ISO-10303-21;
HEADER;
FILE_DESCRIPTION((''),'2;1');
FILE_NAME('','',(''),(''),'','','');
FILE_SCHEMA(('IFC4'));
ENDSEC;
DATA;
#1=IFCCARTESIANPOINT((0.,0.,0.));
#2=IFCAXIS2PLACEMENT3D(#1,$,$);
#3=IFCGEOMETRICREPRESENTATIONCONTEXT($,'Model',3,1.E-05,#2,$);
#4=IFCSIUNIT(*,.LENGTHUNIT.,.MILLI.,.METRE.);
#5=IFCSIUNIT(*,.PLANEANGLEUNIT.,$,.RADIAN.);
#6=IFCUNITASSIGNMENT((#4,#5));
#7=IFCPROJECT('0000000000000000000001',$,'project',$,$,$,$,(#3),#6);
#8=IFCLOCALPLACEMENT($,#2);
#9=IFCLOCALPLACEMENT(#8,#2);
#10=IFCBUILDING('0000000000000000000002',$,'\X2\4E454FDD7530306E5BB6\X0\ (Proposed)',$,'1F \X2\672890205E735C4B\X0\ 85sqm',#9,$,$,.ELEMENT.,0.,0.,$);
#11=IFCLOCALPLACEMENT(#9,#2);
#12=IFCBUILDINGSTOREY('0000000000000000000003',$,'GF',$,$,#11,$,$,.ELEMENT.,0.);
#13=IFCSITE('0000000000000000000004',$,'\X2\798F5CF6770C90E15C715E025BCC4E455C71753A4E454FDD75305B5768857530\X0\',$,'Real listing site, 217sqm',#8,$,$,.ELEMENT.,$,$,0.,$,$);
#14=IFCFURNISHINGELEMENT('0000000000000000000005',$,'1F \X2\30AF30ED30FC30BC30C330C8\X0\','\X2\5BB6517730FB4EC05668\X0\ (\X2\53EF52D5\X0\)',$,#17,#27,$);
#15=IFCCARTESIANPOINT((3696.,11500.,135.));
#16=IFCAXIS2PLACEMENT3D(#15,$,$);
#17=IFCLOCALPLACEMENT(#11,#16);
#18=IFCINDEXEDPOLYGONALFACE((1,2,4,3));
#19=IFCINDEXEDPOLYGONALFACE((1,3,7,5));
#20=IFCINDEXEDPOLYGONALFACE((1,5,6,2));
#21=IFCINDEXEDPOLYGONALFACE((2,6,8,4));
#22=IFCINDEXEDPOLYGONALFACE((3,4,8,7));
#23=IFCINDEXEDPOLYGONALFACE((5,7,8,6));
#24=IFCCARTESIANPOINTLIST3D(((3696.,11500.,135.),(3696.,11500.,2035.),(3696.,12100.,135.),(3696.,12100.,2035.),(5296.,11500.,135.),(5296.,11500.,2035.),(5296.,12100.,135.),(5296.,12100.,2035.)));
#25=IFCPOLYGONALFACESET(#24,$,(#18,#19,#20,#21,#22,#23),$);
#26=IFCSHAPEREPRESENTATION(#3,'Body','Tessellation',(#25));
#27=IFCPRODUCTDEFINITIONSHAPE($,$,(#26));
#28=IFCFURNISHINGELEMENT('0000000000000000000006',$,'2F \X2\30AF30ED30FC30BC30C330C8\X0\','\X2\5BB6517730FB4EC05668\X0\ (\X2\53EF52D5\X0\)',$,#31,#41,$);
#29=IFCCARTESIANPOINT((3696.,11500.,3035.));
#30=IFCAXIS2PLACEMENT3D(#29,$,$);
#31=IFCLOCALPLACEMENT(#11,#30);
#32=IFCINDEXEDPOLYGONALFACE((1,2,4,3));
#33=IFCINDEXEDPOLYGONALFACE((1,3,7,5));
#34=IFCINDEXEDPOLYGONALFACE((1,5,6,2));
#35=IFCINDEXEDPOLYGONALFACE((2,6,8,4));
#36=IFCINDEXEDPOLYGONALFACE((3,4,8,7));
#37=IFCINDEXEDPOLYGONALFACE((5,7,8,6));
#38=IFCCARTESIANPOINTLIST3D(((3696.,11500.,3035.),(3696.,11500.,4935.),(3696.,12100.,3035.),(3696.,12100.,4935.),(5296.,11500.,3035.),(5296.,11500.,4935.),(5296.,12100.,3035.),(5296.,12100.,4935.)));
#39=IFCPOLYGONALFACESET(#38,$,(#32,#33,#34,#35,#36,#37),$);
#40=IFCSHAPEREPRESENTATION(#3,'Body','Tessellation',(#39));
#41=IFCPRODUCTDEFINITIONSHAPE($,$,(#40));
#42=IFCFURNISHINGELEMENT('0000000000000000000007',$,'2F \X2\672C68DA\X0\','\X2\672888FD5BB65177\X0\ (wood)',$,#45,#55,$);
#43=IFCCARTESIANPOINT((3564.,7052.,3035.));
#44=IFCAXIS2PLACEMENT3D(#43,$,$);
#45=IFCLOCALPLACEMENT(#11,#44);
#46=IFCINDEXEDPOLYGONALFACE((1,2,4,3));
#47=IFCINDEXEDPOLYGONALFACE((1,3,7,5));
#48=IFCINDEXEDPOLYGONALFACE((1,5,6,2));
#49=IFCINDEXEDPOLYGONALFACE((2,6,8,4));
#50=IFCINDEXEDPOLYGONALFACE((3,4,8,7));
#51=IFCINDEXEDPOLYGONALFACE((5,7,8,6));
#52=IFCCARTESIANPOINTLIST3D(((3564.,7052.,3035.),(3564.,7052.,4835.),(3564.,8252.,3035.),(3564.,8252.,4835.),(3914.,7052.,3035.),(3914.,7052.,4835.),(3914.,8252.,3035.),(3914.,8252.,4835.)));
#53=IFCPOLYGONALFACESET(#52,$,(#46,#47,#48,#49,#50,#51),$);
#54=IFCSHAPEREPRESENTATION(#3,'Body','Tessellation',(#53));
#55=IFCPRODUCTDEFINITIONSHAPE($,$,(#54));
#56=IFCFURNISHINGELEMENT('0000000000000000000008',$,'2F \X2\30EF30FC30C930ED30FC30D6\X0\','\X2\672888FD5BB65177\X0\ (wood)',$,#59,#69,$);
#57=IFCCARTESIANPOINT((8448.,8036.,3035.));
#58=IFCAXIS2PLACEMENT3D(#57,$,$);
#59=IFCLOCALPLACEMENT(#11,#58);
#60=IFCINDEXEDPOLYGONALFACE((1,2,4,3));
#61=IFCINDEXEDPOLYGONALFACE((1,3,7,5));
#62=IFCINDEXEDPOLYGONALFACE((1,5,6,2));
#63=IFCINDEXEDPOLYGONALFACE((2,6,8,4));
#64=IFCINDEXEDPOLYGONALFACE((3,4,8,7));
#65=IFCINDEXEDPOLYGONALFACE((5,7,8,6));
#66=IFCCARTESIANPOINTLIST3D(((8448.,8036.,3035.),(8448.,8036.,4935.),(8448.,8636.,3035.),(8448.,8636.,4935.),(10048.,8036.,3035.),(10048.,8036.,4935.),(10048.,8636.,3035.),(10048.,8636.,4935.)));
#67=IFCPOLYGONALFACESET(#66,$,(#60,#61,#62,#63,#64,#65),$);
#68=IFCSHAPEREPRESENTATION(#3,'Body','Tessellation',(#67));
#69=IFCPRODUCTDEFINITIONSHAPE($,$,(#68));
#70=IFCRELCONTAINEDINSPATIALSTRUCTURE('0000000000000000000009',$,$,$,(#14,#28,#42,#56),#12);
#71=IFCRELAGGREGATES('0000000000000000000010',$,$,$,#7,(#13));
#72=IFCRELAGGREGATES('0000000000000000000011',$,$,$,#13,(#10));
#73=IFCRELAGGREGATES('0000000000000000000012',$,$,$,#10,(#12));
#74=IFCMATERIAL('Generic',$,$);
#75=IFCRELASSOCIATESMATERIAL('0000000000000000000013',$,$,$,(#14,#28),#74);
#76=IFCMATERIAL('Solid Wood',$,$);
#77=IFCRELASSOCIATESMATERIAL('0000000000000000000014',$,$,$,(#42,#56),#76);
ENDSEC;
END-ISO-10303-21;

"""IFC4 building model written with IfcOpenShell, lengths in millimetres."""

from ifc_helpers import new_model, si_unit, frame, frame_2d, origin, place, context, project, spatial, rectangle, extrude, material, element, save


model = new_model("IFC4")

# Units and contexts
model_context = context("Model", 3, precision=1e-05, world=origin())
ifc_project = project(units=[si_unit("LENGTHUNIT", "METRE", prefix="MILLI"), si_unit("PLANEANGLEUNIT", "RADIAN")], contexts=[model_context])

# Site, building, storey
site_placement = place(None, origin())
site = spatial("IfcSite", under=ifc_project, at=site_placement, Name="福島県郡山市富久山町久保田字梅田", ObjectType="Real listing site, 217sqm", CompositionType="ELEMENT", RefElevation=0.0)
building_placement = place(site_placement, origin())
building = spatial("IfcBuilding", under=site, at=building_placement, Name="久保田の家 (Proposed)", ObjectType="1F 木造平屋 85sqm", CompositionType="ELEMENT", ElevationOfRefHeight=0.0, ElevationOfTerrain=0.0)
storey_placement = place(building_placement, origin())
storey = spatial("IfcBuildingStorey", under=building, at=storey_placement, Name="GF", CompositionType="ELEMENT", Elevation=0.0)

# Shared definitions
ifc_material_1 = material(Name="Solid Wood")

# Shared definitions
ifc_material_2 = material(Name="Generic")

# Furnishing elements
furnishing_1_placement = place(storey_placement, frame((3696.0, 11500.0, 135.0)))
element("IfcFurnishingElement", 1, at=furnishing_1_placement, inside=storey, material=ifc_material_2, Name="1F クローゼット", Description="家具・什器 (可動)", context=model_context, shape_type="SweptSolid", body=[
    extrude(rectangle(XDim=1600.0, YDim=600.0, at=frame_2d((800.0, 300.0))), frame((3696.0, 11500.0, 135.0)), (0.0, 0.0, 1.0), 1900.0),
])
furnishing_2_placement = place(storey_placement, frame((3696.0, 11500.0, 3035.0)))
element("IfcFurnishingElement", 2, at=furnishing_2_placement, inside=storey, material=ifc_material_2, Name="2F クローゼット", Description="家具・什器 (可動)", context=model_context, shape_type="SweptSolid", body=[
    extrude(rectangle(XDim=1600.0, YDim=600.0, at=frame_2d((800.0, 300.0))), frame((3696.0, 11500.0, 3035.0)), (0.0, 0.0, 1.0), 1900.0),
])
furnishing_3_placement = place(storey_placement, frame((3564.0, 7052.0, 3035.0)))
element("IfcFurnishingElement", 3, at=furnishing_3_placement, inside=storey, material=ifc_material_1, Name="2F 本棚", Description="木製家具 (wood)", context=model_context, shape_type="SweptSolid", body=[
    extrude(rectangle(XDim=350.0, YDim=1200.0, at=frame_2d((175.0, 600.0))), frame((3564.0, 7052.0, 3035.0)), (0.0, 0.0, 1.0), 1800.0),
])
furnishing_4_placement = place(storey_placement, frame((8448.0, 8036.0, 3035.0)))
element("IfcFurnishingElement", 4, at=furnishing_4_placement, inside=storey, material=ifc_material_1, Name="2F ワードローブ", Description="木製家具 (wood)", context=model_context, shape_type="SweptSolid", body=[
    extrude(rectangle(XDim=1600.0, YDim=600.0, at=frame_2d((800.0, 300.0))), frame((8448.0, 8036.0, 3035.0)), (0.0, 0.0, 1.0), 1900.0),
])

save(model, "model.ifc")
